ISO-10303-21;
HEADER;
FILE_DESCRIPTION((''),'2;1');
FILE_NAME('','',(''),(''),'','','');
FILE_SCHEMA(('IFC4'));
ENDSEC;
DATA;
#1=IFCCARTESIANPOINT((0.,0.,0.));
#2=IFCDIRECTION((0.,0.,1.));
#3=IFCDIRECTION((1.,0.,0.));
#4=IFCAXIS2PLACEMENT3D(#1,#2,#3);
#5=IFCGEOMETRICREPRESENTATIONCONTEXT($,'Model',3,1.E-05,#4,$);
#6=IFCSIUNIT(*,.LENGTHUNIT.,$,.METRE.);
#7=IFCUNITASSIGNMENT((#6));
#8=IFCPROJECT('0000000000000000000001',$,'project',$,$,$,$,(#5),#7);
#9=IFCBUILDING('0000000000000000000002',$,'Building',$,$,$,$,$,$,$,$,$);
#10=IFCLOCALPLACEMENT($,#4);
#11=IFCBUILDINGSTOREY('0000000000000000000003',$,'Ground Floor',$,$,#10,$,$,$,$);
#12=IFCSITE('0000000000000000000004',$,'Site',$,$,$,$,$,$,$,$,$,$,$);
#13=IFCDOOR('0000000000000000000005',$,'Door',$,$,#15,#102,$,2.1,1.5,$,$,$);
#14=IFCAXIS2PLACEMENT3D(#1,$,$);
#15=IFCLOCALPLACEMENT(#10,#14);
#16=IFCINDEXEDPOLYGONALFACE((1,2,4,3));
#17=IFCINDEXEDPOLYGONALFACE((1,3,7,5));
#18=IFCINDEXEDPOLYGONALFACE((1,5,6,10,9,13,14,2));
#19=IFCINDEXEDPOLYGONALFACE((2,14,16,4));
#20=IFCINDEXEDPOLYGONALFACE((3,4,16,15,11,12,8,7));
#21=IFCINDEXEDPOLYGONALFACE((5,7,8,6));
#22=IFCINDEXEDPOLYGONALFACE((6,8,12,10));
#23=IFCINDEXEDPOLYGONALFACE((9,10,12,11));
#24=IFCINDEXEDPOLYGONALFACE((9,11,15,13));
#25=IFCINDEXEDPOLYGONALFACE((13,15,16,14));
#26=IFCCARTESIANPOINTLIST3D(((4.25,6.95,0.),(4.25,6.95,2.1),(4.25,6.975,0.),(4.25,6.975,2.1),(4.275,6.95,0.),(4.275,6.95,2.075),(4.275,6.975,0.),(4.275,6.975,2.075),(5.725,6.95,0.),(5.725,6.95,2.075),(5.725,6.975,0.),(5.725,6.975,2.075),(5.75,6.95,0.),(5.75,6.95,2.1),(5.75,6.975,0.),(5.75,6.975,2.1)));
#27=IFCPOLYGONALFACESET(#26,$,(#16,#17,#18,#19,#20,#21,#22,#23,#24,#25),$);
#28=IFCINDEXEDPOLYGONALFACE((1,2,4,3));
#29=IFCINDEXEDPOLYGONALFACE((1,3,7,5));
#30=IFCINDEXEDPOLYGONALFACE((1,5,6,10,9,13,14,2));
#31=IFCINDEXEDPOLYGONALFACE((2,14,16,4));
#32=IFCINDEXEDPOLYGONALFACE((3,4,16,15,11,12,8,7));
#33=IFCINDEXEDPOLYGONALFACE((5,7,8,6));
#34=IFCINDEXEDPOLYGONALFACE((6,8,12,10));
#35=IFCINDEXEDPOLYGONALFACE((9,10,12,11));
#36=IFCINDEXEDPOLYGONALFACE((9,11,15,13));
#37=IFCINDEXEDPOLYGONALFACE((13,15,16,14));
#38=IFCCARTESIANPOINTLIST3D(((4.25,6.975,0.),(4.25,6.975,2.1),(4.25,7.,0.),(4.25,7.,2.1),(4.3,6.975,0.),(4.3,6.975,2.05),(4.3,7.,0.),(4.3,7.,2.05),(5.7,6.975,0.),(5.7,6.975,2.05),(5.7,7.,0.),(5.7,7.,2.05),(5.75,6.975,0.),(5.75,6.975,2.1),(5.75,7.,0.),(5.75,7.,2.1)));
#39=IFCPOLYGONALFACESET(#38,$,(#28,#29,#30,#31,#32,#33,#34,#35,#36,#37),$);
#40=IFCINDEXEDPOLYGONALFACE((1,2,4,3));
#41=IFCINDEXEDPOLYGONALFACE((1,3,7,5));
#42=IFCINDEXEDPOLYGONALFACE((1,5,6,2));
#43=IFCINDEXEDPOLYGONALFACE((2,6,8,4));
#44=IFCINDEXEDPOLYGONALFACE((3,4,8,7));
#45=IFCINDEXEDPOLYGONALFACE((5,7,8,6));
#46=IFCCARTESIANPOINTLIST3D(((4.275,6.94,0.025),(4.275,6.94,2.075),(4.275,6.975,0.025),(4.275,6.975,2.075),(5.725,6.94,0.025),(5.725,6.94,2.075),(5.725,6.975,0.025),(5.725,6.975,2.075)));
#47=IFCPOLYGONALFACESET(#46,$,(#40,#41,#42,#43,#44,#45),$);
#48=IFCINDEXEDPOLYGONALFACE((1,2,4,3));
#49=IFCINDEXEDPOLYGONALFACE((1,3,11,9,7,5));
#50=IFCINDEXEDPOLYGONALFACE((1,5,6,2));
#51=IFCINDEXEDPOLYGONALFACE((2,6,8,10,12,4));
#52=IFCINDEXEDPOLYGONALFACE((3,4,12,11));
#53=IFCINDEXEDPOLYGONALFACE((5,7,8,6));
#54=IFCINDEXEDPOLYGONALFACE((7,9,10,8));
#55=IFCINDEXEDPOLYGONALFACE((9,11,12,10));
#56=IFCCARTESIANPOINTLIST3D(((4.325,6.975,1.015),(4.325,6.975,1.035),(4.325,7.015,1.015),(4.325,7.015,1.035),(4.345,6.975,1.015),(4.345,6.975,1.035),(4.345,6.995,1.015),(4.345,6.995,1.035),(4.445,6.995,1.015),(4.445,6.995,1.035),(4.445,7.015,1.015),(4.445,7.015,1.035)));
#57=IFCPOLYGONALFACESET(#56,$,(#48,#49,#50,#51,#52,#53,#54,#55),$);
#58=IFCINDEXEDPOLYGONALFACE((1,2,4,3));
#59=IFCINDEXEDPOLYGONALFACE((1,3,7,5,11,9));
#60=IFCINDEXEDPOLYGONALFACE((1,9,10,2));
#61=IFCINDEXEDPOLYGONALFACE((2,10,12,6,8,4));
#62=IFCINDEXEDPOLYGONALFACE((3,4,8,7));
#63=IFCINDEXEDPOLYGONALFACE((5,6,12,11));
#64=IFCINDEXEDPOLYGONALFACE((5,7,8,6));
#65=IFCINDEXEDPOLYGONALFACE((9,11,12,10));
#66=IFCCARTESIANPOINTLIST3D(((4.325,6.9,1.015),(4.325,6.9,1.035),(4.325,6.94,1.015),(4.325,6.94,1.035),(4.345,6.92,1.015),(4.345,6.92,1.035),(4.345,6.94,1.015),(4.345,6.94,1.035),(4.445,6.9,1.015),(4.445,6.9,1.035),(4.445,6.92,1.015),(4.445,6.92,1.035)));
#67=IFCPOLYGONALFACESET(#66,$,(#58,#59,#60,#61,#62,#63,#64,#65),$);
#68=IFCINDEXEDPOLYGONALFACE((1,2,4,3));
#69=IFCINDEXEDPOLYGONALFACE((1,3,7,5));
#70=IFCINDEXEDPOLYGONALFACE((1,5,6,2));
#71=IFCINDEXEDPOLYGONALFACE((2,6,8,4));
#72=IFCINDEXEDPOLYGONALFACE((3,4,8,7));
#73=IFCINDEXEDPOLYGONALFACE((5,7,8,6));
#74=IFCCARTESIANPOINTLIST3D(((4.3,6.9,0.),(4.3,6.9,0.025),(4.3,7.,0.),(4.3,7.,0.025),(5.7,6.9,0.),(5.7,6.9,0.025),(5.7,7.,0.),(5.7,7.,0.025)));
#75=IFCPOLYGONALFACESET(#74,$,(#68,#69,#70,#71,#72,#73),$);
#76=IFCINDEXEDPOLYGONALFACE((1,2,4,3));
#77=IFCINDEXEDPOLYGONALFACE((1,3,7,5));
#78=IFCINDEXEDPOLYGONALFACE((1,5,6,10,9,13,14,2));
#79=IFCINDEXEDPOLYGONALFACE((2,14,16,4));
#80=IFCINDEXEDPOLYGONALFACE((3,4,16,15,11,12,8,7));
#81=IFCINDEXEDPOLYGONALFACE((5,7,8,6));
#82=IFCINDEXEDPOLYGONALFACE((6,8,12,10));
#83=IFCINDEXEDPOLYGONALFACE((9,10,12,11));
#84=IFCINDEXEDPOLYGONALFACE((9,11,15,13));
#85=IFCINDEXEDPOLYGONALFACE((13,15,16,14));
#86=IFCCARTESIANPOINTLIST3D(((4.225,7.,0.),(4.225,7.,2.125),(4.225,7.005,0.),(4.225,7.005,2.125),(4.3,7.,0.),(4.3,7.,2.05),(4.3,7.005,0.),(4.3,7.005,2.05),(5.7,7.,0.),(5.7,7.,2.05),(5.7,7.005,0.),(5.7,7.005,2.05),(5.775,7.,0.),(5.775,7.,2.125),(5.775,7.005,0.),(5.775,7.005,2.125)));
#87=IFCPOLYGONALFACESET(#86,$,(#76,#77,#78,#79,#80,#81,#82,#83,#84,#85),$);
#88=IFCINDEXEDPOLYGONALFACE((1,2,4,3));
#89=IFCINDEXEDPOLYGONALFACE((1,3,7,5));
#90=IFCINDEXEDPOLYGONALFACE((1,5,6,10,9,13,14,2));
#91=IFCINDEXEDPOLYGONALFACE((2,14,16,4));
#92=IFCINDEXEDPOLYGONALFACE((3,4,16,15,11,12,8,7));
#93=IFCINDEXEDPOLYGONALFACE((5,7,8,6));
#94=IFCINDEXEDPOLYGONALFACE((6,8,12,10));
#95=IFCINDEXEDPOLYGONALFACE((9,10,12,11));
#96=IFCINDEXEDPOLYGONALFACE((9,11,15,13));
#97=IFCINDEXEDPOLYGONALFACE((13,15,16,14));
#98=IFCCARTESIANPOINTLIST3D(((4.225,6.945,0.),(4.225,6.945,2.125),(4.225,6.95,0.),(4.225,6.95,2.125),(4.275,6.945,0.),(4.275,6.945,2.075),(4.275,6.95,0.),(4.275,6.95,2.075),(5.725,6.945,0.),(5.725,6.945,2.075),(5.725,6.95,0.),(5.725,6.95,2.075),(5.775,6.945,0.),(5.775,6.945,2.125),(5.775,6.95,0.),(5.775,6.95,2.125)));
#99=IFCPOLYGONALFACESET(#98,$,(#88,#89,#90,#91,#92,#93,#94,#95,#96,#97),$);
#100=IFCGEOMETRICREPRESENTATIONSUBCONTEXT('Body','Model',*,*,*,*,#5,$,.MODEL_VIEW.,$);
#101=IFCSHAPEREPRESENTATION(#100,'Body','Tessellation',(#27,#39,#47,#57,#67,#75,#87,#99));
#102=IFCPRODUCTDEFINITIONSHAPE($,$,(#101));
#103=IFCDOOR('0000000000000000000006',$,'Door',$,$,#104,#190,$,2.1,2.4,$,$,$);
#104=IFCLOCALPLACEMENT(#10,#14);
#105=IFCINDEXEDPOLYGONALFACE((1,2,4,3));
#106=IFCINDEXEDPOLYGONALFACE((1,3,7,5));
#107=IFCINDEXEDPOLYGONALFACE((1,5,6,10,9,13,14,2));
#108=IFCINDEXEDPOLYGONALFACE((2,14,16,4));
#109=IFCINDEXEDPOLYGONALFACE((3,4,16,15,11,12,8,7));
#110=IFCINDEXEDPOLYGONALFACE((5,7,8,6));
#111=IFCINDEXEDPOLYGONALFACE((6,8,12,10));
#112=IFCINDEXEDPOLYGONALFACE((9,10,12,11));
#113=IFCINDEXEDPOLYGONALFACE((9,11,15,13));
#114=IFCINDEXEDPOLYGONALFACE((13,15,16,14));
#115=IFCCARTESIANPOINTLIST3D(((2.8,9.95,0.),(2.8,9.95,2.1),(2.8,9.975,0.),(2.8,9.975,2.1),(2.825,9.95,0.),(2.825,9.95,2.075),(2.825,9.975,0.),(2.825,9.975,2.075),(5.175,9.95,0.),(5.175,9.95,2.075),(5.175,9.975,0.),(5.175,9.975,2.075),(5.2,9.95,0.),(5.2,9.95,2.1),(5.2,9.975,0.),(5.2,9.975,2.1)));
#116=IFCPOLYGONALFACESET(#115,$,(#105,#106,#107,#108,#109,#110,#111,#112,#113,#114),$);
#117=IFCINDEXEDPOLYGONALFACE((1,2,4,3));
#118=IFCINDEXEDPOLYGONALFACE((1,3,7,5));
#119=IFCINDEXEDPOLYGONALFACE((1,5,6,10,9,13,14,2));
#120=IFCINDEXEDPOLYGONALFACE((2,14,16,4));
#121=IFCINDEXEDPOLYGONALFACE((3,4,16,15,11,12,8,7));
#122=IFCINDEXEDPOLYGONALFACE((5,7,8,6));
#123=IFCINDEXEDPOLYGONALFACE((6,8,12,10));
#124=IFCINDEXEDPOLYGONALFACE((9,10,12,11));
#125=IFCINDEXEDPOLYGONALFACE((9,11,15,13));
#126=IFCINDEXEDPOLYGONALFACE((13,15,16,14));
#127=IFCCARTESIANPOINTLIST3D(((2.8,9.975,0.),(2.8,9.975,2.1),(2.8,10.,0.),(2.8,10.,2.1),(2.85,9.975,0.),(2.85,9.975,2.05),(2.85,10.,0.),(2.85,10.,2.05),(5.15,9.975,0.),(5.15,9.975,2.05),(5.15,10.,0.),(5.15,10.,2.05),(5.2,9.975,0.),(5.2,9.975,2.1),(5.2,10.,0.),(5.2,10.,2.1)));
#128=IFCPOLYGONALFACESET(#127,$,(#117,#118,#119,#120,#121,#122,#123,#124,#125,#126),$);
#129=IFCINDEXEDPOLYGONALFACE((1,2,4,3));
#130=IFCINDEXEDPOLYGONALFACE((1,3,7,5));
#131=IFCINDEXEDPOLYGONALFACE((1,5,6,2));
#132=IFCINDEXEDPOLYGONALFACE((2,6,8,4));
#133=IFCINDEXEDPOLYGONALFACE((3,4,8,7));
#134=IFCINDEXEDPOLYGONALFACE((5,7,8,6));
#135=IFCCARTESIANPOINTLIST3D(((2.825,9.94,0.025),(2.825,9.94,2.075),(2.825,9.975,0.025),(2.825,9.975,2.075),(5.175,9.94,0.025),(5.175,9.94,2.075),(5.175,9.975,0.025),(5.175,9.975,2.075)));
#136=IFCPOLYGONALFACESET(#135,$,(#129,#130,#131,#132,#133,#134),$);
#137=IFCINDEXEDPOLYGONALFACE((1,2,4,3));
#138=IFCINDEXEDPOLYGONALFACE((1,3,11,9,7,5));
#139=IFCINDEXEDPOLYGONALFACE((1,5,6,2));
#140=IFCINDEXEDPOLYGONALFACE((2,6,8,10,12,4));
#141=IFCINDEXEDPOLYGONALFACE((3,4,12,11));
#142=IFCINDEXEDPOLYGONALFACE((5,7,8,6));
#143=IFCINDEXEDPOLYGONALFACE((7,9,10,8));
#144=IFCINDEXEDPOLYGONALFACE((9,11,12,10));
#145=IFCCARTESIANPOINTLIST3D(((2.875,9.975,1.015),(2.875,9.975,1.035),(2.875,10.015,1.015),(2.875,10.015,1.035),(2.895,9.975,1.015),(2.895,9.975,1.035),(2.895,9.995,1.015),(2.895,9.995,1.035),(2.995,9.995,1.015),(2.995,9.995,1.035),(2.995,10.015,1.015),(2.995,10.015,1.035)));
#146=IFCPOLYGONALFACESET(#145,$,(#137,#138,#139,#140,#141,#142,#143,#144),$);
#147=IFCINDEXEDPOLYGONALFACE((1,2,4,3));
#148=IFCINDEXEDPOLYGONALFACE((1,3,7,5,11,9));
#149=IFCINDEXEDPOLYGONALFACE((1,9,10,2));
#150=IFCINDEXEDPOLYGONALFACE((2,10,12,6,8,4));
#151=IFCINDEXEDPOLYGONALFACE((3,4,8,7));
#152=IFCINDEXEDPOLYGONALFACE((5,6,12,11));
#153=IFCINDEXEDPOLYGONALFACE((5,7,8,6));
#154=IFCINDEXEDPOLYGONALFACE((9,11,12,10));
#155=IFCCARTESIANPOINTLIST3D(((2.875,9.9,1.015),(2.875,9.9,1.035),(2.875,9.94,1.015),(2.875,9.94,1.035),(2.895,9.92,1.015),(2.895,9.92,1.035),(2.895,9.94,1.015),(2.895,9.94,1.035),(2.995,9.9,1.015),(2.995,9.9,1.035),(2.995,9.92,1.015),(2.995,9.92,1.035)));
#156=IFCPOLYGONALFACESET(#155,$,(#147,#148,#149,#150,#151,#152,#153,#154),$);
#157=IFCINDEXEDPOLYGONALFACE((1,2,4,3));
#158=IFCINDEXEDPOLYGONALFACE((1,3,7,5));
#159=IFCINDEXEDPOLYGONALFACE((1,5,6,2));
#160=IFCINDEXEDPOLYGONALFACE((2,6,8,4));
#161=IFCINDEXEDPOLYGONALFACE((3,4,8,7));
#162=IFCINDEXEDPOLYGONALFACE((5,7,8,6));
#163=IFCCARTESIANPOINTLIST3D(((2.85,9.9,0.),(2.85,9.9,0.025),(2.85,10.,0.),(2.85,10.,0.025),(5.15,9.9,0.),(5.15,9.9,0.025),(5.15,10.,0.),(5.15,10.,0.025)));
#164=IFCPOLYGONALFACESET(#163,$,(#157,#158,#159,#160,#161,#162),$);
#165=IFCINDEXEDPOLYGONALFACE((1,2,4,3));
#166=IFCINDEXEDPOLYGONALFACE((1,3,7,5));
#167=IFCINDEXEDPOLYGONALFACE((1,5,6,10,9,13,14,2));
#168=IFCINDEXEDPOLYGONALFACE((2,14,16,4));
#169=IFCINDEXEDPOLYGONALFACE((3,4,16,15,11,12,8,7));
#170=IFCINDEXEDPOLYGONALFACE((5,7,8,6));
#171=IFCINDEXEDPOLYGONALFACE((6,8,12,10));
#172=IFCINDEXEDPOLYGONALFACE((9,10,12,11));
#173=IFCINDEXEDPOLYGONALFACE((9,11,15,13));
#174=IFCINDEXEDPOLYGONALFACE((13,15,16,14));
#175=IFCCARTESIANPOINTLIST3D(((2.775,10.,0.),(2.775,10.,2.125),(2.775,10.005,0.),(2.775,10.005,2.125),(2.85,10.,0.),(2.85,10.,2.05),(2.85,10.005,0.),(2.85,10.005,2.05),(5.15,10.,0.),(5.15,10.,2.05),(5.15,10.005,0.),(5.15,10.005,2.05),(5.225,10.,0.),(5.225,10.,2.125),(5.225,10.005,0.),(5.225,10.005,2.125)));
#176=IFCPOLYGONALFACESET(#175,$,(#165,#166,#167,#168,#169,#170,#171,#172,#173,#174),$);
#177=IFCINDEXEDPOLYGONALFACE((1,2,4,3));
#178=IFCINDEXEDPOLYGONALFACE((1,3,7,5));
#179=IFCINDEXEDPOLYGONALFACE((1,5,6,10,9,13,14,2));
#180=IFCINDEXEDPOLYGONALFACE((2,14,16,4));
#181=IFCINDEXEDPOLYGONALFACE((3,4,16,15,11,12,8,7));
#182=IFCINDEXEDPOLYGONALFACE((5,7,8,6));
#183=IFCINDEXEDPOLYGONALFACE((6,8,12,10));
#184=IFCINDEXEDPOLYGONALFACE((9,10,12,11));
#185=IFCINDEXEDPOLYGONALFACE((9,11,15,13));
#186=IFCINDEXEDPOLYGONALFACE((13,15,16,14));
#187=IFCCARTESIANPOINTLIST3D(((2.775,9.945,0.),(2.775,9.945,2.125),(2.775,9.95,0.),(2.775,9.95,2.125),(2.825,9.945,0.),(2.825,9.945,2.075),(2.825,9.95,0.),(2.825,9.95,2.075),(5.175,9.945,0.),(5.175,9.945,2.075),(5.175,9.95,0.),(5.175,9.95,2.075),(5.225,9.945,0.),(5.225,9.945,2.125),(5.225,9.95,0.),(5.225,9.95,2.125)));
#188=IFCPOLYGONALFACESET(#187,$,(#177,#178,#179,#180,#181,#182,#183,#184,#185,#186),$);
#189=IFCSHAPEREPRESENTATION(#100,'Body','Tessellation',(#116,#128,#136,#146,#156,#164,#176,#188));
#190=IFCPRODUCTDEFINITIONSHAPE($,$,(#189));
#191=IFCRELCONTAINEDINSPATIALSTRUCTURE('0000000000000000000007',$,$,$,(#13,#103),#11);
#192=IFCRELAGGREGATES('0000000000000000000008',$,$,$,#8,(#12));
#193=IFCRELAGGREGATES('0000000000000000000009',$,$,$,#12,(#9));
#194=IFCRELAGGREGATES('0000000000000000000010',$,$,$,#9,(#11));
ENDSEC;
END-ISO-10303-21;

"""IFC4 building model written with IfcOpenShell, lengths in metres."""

from ifc_helpers import new_model, si_unit, frame, origin_with_axes, place, context, subcontext, project, spatial, line, indexed_curve, outline, extrude, element, save


model = new_model("IFC4")

# Units and contexts
model_context = context("Model", 3, precision=1e-05, world=origin_with_axes())
body_context = subcontext(model_context, "Body", "Model", "MODEL_VIEW")
ifc_project = project(units=[si_unit("LENGTHUNIT", "METRE")], contexts=[model_context])

# Site, building, storey
site = spatial("IfcSite", under=ifc_project, Name="Site")
building = spatial("IfcBuilding", under=site, Name="Building")
storey_placement = place(None, origin_with_axes())
storey = spatial("IfcBuildingStorey", under=building, at=storey_placement, Name="Ground Floor")

# Doors
door_1_placement = place(storey_placement, frame((5.75, 7.0, 0.0), z_axis=(0.0, 0.0, 1.0), x_axis=(-1.0, 0.0, 0.0)))
element("IfcDoor", 1, at=door_1_placement, inside=storey, Name="Door", OverallHeight=2.1, OverallWidth=1.5, context=body_context, shape_type="SweptSolid", body=[
    extrude(outline(indexed_curve([(0.0, 0.0), (0.0, 2.1), (1.5, 2.1), (1.5, 0.0), (1.475, 0.0), (1.475, 2.075), (0.025, 2.075), (0.025, 0.0)], segments=[line(1, 2, 3, 4, 5, 6, 7, 8, 1)])), frame((0.0, 0.025, 0.0), z_axis=(0.0, -1.0, 0.0), x_axis=(1.0, 0.0, 0.0)), (0.0, 0.0, -1.0), 0.025),
    extrude(outline(indexed_curve([(0.0, 0.0), (0.0, 2.1), (1.5, 2.1), (1.5, 0.0), (1.45, 0.0), (1.45, 2.05), (0.05, 2.05), (0.05, 0.0)], segments=[line(1, 2, 3, 4, 5, 6, 7, 8, 1)])), frame((0.0, 0.0, 0.0), z_axis=(0.0, -1.0, 0.0), x_axis=(1.0, 0.0, 0.0)), (0.0, 0.0, -1.0), 0.025),
    extrude(outline(indexed_curve([(0.0, 0.0), (1.45, 0.0), (1.45, 0.035), (0.0, 0.035)], segments=[line(1, 2, 3, 4, 1)])), frame((0.025, 0.025, 0.025), z_axis=(0.0, 0.0, 1.0), x_axis=(1.0, 0.0, 0.0)), (0.0, 0.0, 1.0), 2.05),
    extrude(outline(indexed_curve([(0.0, 0.0), (0.0, -0.04), (-0.12, -0.04), (-0.12, -0.02), (-0.02, -0.02), (-0.02, 0.0)], segments=[line(1, 2, 3, 4, 5, 6, 1)])), frame((1.425, 0.025, 1.015), z_axis=(0.0, 0.0, 1.0), x_axis=(1.0, 0.0, 0.0)), (0.0, 0.0, 1.0), 0.02),
    extrude(outline(indexed_curve([(0.0, 0.0), (0.0, 0.04), (-0.12, 0.04), (-0.12, 0.02), (-0.02, 0.02), (-0.02, 0.0)], segments=[line(1, 2, 3, 4, 5, 6, 1)])), frame((1.425, 0.06, 1.015), z_axis=(0.0, 0.0, 1.0), x_axis=(1.0, 0.0, 0.0)), (0.0, 0.0, 1.0), 0.02),
    extrude(outline(indexed_curve([(0.0, 0.0), (1.4, 0.0), (1.4, 0.1), (0.0, 0.1)], segments=[line(1, 2, 3, 4, 1)])), frame((0.05, 0.0, 0.0), z_axis=(0.0, 0.0, 1.0), x_axis=(1.0, 0.0, 0.0)), (0.0, 0.0, 1.0), 0.025),
    extrude(outline(indexed_curve([(0.0, 0.0), (0.0, 2.125), (1.55, 2.125), (1.55, 0.0), (1.475, 0.0), (1.475, 2.05), (0.075, 2.05), (0.075, 0.0)], segments=[line(1, 2, 3, 4, 5, 6, 7, 8, 1)])), frame((-0.025, -0.005, 0.0), z_axis=(0.0, -1.0, 0.0), x_axis=(1.0, 0.0, 0.0)), (0.0, 0.0, -1.0), 0.005),
    extrude(outline(indexed_curve([(0.0, 0.0), (0.0, 2.125), (1.55, 2.125), (1.55, 0.0), (1.5, 0.0), (1.5, 2.075), (0.05, 2.075), (0.05, 0.0)], segments=[line(1, 2, 3, 4, 5, 6, 7, 8, 1)])), frame((-0.025, 0.05, 0.0), z_axis=(0.0, -1.0, 0.0), x_axis=(1.0, 0.0, 0.0)), (0.0, 0.0, -1.0), 0.005),
])
door_2_placement = place(storey_placement, frame((5.2, 10.0, 0.0), z_axis=(0.0, 0.0, 1.0), x_axis=(-1.0, 0.0, 0.0)))
element("IfcDoor", 2, at=door_2_placement, inside=storey, Name="Door", OverallHeight=2.1, OverallWidth=2.4, context=body_context, shape_type="SweptSolid", body=[
    extrude(outline(indexed_curve([(0.0, 0.0), (0.0, 2.1), (2.4, 2.1), (2.4, 0.0), (2.375, 0.0), (2.375, 2.075), (0.025, 2.075), (0.025, 0.0)], segments=[line(1, 2, 3, 4, 5, 6, 7, 8, 1)])), frame((0.0, 0.025, 0.0), z_axis=(0.0, -1.0, 0.0), x_axis=(1.0, 0.0, 0.0)), (0.0, 0.0, -1.0), 0.025),
    extrude(outline(indexed_curve([(0.0, 0.0), (0.0, 2.1), (2.4, 2.1), (2.4, 0.0), (2.35, 0.0), (2.35, 2.05), (0.05, 2.05), (0.05, 0.0)], segments=[line(1, 2, 3, 4, 5, 6, 7, 8, 1)])), frame((0.0, 0.0, 0.0), z_axis=(0.0, -1.0, 0.0), x_axis=(1.0, 0.0, 0.0)), (0.0, 0.0, -1.0), 0.025),
    extrude(outline(indexed_curve([(0.0, 0.0), (2.35, 0.0), (2.35, 0.035), (0.0, 0.035)], segments=[line(1, 2, 3, 4, 1)])), frame((0.025, 0.025, 0.025), z_axis=(0.0, 0.0, 1.0), x_axis=(1.0, 0.0, 0.0)), (0.0, 0.0, 1.0), 2.05),
    extrude(outline(indexed_curve([(0.0, 0.0), (0.0, -0.04), (-0.12, -0.04), (-0.12, -0.02), (-0.02, -0.02), (-0.02, 0.0)], segments=[line(1, 2, 3, 4, 5, 6, 1)])), frame((2.325, 0.025, 1.015), z_axis=(0.0, 0.0, 1.0), x_axis=(1.0, 0.0, 0.0)), (0.0, 0.0, 1.0), 0.02),
    extrude(outline(indexed_curve([(0.0, 0.0), (0.0, 0.04), (-0.12, 0.04), (-0.12, 0.02), (-0.02, 0.02), (-0.02, 0.0)], segments=[line(1, 2, 3, 4, 5, 6, 1)])), frame((2.325, 0.06, 1.015), z_axis=(0.0, 0.0, 1.0), x_axis=(1.0, 0.0, 0.0)), (0.0, 0.0, 1.0), 0.02),
    extrude(outline(indexed_curve([(0.0, 0.0), (2.3, 0.0), (2.3, 0.1), (0.0, 0.1)], segments=[line(1, 2, 3, 4, 1)])), frame((0.05, 0.0, 0.0), z_axis=(0.0, 0.0, 1.0), x_axis=(1.0, 0.0, 0.0)), (0.0, 0.0, 1.0), 0.025),
    extrude(outline(indexed_curve([(0.0, 0.0), (0.0, 2.125), (2.45, 2.125), (2.45, 0.0), (2.375, 0.0), (2.375, 2.05), (0.075, 2.05), (0.075, 0.0)], segments=[line(1, 2, 3, 4, 5, 6, 7, 8, 1)])), frame((-0.025, -0.005, 0.0), z_axis=(0.0, -1.0, 0.0), x_axis=(1.0, 0.0, 0.0)), (0.0, 0.0, -1.0), 0.005),
    extrude(outline(indexed_curve([(0.0, 0.0), (0.0, 2.125), (2.45, 2.125), (2.45, 0.0), (2.4, 0.0), (2.4, 2.075), (0.05, 2.075), (0.05, 0.0)], segments=[line(1, 2, 3, 4, 5, 6, 7, 8, 1)])), frame((-0.025, 0.05, 0.0), z_axis=(0.0, -1.0, 0.0), x_axis=(1.0, 0.0, 0.0)), (0.0, 0.0, -1.0), 0.005),
])

save(model, "model.ifc")
